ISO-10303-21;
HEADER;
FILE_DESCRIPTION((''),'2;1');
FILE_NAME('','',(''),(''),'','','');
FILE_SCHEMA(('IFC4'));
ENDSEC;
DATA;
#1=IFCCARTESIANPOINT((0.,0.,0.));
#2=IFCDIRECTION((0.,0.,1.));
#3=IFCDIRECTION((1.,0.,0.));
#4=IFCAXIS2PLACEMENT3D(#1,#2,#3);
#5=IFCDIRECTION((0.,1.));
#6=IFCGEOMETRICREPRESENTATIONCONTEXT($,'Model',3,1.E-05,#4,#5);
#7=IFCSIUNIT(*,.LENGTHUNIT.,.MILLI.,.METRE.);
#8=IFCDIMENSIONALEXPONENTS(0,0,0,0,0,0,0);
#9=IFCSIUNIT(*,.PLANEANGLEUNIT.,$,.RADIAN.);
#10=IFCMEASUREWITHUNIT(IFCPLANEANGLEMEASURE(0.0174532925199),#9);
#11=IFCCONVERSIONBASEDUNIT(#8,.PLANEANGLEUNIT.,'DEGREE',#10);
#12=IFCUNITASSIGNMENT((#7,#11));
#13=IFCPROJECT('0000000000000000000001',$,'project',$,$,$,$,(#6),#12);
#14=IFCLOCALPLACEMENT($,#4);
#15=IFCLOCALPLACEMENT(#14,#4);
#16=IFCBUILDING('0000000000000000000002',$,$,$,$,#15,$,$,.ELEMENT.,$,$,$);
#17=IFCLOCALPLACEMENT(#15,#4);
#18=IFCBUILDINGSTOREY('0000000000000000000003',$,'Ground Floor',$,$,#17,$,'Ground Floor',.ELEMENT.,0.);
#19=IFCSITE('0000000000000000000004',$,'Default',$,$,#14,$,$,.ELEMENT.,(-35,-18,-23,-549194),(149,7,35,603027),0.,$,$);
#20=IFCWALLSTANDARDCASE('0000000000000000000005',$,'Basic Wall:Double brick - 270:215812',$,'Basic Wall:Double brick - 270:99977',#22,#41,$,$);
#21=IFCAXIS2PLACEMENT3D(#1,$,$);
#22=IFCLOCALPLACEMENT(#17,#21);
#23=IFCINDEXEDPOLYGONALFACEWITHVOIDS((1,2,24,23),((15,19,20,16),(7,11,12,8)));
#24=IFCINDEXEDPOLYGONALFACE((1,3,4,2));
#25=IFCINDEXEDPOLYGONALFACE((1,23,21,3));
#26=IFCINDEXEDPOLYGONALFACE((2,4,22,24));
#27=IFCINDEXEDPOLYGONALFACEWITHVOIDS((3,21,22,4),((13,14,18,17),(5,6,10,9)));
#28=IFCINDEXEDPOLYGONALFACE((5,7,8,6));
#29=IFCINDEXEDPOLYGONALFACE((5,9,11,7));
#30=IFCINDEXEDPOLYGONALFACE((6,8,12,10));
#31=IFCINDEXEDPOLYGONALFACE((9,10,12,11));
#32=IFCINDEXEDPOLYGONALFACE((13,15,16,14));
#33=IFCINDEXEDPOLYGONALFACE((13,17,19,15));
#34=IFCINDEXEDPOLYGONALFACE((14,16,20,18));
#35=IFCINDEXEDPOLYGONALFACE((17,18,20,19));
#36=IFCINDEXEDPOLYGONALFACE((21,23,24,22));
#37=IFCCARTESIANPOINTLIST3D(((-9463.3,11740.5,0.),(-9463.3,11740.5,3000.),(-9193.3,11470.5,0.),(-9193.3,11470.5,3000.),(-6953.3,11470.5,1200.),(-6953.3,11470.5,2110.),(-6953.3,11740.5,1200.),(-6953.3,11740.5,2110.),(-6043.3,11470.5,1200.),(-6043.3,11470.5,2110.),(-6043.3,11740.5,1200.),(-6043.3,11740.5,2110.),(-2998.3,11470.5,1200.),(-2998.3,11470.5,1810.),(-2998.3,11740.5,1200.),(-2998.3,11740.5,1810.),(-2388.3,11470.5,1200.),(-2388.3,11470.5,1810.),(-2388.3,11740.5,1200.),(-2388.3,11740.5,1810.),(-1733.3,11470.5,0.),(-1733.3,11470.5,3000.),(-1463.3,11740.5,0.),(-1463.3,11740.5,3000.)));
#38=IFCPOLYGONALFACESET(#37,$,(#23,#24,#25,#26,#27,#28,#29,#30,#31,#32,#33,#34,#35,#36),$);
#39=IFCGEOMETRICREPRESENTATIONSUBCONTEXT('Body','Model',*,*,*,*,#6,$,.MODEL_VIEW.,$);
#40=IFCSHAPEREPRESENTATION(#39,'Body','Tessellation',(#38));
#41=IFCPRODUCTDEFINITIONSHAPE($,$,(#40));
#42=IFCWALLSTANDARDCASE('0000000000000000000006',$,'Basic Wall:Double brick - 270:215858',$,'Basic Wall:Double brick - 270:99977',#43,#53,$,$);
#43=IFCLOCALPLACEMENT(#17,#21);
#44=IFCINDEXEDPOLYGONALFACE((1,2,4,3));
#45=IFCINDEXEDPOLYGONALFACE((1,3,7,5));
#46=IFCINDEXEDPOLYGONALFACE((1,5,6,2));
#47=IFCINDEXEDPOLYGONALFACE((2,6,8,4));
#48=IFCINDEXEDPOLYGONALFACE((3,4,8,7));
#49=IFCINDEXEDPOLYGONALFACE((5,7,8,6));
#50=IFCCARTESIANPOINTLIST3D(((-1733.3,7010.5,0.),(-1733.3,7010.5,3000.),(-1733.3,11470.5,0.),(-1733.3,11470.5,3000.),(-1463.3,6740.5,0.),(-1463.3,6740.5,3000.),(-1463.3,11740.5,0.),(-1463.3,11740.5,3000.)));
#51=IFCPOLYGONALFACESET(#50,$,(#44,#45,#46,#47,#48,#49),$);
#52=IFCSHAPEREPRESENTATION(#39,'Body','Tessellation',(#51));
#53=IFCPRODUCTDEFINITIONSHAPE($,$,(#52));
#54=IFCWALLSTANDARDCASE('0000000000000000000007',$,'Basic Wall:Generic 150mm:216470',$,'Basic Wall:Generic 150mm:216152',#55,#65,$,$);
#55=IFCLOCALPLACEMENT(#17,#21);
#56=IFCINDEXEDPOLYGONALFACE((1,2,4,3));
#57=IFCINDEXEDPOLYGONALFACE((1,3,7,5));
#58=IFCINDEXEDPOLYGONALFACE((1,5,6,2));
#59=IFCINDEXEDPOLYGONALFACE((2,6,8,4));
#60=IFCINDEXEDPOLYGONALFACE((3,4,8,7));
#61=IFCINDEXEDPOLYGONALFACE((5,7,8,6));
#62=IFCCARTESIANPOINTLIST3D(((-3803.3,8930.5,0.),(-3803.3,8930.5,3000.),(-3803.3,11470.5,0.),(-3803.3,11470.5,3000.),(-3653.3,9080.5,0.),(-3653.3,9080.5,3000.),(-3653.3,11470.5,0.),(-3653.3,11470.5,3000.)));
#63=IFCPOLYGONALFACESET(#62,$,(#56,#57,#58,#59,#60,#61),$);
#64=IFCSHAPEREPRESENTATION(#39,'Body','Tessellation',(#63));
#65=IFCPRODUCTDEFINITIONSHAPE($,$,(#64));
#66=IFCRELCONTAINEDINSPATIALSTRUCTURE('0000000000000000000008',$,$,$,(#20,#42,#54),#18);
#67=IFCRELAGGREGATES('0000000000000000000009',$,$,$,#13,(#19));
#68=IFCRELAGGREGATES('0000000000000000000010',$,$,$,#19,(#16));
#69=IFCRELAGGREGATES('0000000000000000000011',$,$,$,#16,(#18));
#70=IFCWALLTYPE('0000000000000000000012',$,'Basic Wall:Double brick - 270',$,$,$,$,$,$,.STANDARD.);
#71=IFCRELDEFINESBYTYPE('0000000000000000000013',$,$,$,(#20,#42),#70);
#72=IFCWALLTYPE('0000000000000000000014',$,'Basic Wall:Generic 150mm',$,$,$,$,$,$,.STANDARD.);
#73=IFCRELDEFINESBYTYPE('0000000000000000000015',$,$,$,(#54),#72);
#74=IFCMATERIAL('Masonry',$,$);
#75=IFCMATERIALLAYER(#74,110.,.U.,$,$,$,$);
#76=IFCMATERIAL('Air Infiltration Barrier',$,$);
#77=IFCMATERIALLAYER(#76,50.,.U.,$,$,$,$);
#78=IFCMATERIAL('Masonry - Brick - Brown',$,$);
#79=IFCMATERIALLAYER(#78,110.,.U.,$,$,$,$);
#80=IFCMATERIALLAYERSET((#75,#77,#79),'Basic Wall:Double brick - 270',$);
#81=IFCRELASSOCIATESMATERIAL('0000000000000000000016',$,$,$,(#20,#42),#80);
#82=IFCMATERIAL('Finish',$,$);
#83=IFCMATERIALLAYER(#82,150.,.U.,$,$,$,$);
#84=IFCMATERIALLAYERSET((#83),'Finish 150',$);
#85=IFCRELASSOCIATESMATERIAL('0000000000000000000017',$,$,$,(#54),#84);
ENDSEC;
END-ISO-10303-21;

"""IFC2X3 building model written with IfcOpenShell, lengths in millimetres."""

from ifc_helpers import new_model, entity, si_unit, converted_unit, direction, frame, origin_with_axes, place, context, subcontext, project, spatial, polyline, outline, extrude, material, layer, layer_set, layer_usage, type_object, element, save


model = new_model("IFC2X3")

# Units and contexts
model_context = context("Model", 3, precision=1e-05, world=origin_with_axes(), true_north=direction((0.0, 1.0)))
body_context = subcontext(model_context, "Body", "Model", "MODEL_VIEW")
ifc_project = project(units=[si_unit("LENGTHUNIT", "METRE", prefix="MILLI"), converted_unit("PLANEANGLEUNIT", "DEGREE", entity("IfcPlaneAngleMeasure", 0.0174532925199), si_unit("PLANEANGLEUNIT", "RADIAN"), dimensions=[0, 0, 0, 0, 0, 0, 0])], contexts=[model_context])

# Site, building, storey
site_placement = place(None, origin_with_axes())
site = spatial("IfcSite", under=ifc_project, at=site_placement, Name="Default", CompositionType="ELEMENT", RefLatitude=(-35, -18, -23, -549194), RefLongitude=(149, 7, 35, 603027), RefElevation=0.0)
building_placement = place(site_placement, origin_with_axes())
building = spatial("IfcBuilding", under=site, at=building_placement, CompositionType="ELEMENT")
storey_placement = place(building_placement, origin_with_axes())
storey = spatial("IfcBuildingStorey", under=building, at=storey_placement, Name="Ground Floor", LongName="Ground Floor", CompositionType="ELEMENT", Elevation=0.0)

# Wall, openings
ifc_material_1 = material(Name="Masonry")
ifc_layer_1 = layer(ifc_material_1, 110.0, ventilated="UNKNOWN")
ifc_material_2 = material(Name="Air Infiltration Barrier")
ifc_layer_2 = layer(ifc_material_2, 50.0, ventilated="UNKNOWN")
ifc_material_3 = material(Name="Masonry - Brick - Brown")
ifc_layer_3 = layer(ifc_material_3, 110.0, ventilated="UNKNOWN")
ifc_layer_set_1 = layer_set([ifc_layer_1, ifc_layer_2, ifc_layer_3], Name="Basic Wall:Double brick - 270")
ifc_layer_usage_1 = layer_usage(ifc_layer_set_1, "AXIS2", "POSITIVE", -135.0)
wall_type_1 = type_object("IfcWallType", Name="Basic Wall:Double brick - 270", PredefinedType="STANDARD")
wall_1_placement = place(storey_placement, frame((-9328.3, 11605.5, 0.0), z_axis=(0.0, 0.0, 1.0), x_axis=(1.0, 0.0, 0.0)))
wall_1 = element("IfcWallStandardCase", 1, at=wall_1_placement, inside=storey, type_object=wall_type_1, material=ifc_layer_usage_1, Name="Basic Wall:Double brick - 270:215812", ObjectType="Basic Wall:Double brick - 270:99977", context=body_context, shape_type="SweptSolid", body=[
    extrude(outline(polyline([(135.0, -135.0), (7595.0, -135.0), (7865.0, 135.0), (-135.0, 135.0), (135.0, -135.0)])), origin_with_axes(), (0.0, 0.0, 1.0), 3000.0),
])
opening_1_placement = place(wall_1_placement, frame((6635.0, 0.0, 1200.0), z_axis=(0.0, 0.0, 1.0), x_axis=(1.0, 0.0, 0.0)))
element("IfcOpeningElement", 2, at=opening_1_placement, cuts=wall_1, context=body_context, shape_type="SweptSolid", body=[
    extrude(outline(polyline([(-305.0, 0.0), (-305.0, -610.0), (305.0, -610.0), (305.0, 0.0), (-305.0, 0.0)])), frame((0.0, -135.0, 0.0), z_axis=(0.0, 1.0, 0.0), x_axis=(1.0, 0.0, 0.0)), (0.0, 0.0, 1.0), 270.0),
])
opening_2_placement = place(wall_1_placement, frame((2830.0, 0.0, 1200.0), z_axis=(0.0, 0.0, 1.0), x_axis=(1.0, 0.0, 0.0)))
element("IfcOpeningElement", 3, at=opening_2_placement, cuts=wall_1, context=body_context, shape_type="SweptSolid", body=[
    extrude(outline(polyline([(455.0, -910.0), (455.0, 0.0), (-455.0, 0.0), (-455.0, -910.0), (455.0, -910.0)])), frame((0.0, -135.0, 0.0), z_axis=(0.0, 1.0, 0.0), x_axis=(1.0, 0.0, 0.0)), (0.0, 0.0, 1.0), 270.0),
])

# Walls
ifc_layer_usage_2 = layer_usage(ifc_layer_set_1, "AXIS2", "POSITIVE", -135.0)
wall_2_placement = place(storey_placement, frame((-1598.3, 11605.5, 0.0), z_axis=(0.0, 0.0, 1.0), x_axis=(0.0, -1.0, 0.0)))
element("IfcWallStandardCase", 4, at=wall_2_placement, inside=storey, type_object=wall_type_1, material=ifc_layer_usage_2, Name="Basic Wall:Double brick - 270:215858", ObjectType="Basic Wall:Double brick - 270:99977", context=body_context, shape_type="SweptSolid", body=[
    extrude(outline(polyline([(135.0, -135.0), (4595.0, -135.0), (4865.0, 135.0), (-135.0, 135.0), (135.0, -135.0)])), origin_with_axes(), (0.0, 0.0, 1.0), 3000.0),
])
ifc_material_4 = material(Name="Finish")
ifc_layer_4 = layer(ifc_material_4, 150.0, ventilated="UNKNOWN")
ifc_layer_set_2 = layer_set([ifc_layer_4], Name="Finish 150")
ifc_layer_usage_3 = layer_usage(ifc_layer_set_2, "AXIS2", "POSITIVE", -75.0)
wall_type_2 = type_object("IfcWallType", Name="Basic Wall:Generic 150mm", PredefinedType="STANDARD")
wall_3_placement = place(storey_placement, frame((-3728.3, 9005.5, 0.0), z_axis=(0.0, 0.0, 1.0), x_axis=(0.0, 1.0, 0.0)))
element("IfcWallStandardCase", 5, at=wall_3_placement, inside=storey, type_object=wall_type_2, material=ifc_layer_usage_3, Name="Basic Wall:Generic 150mm:216470", ObjectType="Basic Wall:Generic 150mm:216152", context=body_context, shape_type="SweptSolid", body=[
    extrude(outline(polyline([(75.0, -75.0), (2465.0, -75.0), (2465.0, 75.0), (-75.0, 75.0), (75.0, -75.0)])), origin_with_axes(), (0.0, 0.0, 1.0), 3000.0),
])

save(model, "model.ifc")
